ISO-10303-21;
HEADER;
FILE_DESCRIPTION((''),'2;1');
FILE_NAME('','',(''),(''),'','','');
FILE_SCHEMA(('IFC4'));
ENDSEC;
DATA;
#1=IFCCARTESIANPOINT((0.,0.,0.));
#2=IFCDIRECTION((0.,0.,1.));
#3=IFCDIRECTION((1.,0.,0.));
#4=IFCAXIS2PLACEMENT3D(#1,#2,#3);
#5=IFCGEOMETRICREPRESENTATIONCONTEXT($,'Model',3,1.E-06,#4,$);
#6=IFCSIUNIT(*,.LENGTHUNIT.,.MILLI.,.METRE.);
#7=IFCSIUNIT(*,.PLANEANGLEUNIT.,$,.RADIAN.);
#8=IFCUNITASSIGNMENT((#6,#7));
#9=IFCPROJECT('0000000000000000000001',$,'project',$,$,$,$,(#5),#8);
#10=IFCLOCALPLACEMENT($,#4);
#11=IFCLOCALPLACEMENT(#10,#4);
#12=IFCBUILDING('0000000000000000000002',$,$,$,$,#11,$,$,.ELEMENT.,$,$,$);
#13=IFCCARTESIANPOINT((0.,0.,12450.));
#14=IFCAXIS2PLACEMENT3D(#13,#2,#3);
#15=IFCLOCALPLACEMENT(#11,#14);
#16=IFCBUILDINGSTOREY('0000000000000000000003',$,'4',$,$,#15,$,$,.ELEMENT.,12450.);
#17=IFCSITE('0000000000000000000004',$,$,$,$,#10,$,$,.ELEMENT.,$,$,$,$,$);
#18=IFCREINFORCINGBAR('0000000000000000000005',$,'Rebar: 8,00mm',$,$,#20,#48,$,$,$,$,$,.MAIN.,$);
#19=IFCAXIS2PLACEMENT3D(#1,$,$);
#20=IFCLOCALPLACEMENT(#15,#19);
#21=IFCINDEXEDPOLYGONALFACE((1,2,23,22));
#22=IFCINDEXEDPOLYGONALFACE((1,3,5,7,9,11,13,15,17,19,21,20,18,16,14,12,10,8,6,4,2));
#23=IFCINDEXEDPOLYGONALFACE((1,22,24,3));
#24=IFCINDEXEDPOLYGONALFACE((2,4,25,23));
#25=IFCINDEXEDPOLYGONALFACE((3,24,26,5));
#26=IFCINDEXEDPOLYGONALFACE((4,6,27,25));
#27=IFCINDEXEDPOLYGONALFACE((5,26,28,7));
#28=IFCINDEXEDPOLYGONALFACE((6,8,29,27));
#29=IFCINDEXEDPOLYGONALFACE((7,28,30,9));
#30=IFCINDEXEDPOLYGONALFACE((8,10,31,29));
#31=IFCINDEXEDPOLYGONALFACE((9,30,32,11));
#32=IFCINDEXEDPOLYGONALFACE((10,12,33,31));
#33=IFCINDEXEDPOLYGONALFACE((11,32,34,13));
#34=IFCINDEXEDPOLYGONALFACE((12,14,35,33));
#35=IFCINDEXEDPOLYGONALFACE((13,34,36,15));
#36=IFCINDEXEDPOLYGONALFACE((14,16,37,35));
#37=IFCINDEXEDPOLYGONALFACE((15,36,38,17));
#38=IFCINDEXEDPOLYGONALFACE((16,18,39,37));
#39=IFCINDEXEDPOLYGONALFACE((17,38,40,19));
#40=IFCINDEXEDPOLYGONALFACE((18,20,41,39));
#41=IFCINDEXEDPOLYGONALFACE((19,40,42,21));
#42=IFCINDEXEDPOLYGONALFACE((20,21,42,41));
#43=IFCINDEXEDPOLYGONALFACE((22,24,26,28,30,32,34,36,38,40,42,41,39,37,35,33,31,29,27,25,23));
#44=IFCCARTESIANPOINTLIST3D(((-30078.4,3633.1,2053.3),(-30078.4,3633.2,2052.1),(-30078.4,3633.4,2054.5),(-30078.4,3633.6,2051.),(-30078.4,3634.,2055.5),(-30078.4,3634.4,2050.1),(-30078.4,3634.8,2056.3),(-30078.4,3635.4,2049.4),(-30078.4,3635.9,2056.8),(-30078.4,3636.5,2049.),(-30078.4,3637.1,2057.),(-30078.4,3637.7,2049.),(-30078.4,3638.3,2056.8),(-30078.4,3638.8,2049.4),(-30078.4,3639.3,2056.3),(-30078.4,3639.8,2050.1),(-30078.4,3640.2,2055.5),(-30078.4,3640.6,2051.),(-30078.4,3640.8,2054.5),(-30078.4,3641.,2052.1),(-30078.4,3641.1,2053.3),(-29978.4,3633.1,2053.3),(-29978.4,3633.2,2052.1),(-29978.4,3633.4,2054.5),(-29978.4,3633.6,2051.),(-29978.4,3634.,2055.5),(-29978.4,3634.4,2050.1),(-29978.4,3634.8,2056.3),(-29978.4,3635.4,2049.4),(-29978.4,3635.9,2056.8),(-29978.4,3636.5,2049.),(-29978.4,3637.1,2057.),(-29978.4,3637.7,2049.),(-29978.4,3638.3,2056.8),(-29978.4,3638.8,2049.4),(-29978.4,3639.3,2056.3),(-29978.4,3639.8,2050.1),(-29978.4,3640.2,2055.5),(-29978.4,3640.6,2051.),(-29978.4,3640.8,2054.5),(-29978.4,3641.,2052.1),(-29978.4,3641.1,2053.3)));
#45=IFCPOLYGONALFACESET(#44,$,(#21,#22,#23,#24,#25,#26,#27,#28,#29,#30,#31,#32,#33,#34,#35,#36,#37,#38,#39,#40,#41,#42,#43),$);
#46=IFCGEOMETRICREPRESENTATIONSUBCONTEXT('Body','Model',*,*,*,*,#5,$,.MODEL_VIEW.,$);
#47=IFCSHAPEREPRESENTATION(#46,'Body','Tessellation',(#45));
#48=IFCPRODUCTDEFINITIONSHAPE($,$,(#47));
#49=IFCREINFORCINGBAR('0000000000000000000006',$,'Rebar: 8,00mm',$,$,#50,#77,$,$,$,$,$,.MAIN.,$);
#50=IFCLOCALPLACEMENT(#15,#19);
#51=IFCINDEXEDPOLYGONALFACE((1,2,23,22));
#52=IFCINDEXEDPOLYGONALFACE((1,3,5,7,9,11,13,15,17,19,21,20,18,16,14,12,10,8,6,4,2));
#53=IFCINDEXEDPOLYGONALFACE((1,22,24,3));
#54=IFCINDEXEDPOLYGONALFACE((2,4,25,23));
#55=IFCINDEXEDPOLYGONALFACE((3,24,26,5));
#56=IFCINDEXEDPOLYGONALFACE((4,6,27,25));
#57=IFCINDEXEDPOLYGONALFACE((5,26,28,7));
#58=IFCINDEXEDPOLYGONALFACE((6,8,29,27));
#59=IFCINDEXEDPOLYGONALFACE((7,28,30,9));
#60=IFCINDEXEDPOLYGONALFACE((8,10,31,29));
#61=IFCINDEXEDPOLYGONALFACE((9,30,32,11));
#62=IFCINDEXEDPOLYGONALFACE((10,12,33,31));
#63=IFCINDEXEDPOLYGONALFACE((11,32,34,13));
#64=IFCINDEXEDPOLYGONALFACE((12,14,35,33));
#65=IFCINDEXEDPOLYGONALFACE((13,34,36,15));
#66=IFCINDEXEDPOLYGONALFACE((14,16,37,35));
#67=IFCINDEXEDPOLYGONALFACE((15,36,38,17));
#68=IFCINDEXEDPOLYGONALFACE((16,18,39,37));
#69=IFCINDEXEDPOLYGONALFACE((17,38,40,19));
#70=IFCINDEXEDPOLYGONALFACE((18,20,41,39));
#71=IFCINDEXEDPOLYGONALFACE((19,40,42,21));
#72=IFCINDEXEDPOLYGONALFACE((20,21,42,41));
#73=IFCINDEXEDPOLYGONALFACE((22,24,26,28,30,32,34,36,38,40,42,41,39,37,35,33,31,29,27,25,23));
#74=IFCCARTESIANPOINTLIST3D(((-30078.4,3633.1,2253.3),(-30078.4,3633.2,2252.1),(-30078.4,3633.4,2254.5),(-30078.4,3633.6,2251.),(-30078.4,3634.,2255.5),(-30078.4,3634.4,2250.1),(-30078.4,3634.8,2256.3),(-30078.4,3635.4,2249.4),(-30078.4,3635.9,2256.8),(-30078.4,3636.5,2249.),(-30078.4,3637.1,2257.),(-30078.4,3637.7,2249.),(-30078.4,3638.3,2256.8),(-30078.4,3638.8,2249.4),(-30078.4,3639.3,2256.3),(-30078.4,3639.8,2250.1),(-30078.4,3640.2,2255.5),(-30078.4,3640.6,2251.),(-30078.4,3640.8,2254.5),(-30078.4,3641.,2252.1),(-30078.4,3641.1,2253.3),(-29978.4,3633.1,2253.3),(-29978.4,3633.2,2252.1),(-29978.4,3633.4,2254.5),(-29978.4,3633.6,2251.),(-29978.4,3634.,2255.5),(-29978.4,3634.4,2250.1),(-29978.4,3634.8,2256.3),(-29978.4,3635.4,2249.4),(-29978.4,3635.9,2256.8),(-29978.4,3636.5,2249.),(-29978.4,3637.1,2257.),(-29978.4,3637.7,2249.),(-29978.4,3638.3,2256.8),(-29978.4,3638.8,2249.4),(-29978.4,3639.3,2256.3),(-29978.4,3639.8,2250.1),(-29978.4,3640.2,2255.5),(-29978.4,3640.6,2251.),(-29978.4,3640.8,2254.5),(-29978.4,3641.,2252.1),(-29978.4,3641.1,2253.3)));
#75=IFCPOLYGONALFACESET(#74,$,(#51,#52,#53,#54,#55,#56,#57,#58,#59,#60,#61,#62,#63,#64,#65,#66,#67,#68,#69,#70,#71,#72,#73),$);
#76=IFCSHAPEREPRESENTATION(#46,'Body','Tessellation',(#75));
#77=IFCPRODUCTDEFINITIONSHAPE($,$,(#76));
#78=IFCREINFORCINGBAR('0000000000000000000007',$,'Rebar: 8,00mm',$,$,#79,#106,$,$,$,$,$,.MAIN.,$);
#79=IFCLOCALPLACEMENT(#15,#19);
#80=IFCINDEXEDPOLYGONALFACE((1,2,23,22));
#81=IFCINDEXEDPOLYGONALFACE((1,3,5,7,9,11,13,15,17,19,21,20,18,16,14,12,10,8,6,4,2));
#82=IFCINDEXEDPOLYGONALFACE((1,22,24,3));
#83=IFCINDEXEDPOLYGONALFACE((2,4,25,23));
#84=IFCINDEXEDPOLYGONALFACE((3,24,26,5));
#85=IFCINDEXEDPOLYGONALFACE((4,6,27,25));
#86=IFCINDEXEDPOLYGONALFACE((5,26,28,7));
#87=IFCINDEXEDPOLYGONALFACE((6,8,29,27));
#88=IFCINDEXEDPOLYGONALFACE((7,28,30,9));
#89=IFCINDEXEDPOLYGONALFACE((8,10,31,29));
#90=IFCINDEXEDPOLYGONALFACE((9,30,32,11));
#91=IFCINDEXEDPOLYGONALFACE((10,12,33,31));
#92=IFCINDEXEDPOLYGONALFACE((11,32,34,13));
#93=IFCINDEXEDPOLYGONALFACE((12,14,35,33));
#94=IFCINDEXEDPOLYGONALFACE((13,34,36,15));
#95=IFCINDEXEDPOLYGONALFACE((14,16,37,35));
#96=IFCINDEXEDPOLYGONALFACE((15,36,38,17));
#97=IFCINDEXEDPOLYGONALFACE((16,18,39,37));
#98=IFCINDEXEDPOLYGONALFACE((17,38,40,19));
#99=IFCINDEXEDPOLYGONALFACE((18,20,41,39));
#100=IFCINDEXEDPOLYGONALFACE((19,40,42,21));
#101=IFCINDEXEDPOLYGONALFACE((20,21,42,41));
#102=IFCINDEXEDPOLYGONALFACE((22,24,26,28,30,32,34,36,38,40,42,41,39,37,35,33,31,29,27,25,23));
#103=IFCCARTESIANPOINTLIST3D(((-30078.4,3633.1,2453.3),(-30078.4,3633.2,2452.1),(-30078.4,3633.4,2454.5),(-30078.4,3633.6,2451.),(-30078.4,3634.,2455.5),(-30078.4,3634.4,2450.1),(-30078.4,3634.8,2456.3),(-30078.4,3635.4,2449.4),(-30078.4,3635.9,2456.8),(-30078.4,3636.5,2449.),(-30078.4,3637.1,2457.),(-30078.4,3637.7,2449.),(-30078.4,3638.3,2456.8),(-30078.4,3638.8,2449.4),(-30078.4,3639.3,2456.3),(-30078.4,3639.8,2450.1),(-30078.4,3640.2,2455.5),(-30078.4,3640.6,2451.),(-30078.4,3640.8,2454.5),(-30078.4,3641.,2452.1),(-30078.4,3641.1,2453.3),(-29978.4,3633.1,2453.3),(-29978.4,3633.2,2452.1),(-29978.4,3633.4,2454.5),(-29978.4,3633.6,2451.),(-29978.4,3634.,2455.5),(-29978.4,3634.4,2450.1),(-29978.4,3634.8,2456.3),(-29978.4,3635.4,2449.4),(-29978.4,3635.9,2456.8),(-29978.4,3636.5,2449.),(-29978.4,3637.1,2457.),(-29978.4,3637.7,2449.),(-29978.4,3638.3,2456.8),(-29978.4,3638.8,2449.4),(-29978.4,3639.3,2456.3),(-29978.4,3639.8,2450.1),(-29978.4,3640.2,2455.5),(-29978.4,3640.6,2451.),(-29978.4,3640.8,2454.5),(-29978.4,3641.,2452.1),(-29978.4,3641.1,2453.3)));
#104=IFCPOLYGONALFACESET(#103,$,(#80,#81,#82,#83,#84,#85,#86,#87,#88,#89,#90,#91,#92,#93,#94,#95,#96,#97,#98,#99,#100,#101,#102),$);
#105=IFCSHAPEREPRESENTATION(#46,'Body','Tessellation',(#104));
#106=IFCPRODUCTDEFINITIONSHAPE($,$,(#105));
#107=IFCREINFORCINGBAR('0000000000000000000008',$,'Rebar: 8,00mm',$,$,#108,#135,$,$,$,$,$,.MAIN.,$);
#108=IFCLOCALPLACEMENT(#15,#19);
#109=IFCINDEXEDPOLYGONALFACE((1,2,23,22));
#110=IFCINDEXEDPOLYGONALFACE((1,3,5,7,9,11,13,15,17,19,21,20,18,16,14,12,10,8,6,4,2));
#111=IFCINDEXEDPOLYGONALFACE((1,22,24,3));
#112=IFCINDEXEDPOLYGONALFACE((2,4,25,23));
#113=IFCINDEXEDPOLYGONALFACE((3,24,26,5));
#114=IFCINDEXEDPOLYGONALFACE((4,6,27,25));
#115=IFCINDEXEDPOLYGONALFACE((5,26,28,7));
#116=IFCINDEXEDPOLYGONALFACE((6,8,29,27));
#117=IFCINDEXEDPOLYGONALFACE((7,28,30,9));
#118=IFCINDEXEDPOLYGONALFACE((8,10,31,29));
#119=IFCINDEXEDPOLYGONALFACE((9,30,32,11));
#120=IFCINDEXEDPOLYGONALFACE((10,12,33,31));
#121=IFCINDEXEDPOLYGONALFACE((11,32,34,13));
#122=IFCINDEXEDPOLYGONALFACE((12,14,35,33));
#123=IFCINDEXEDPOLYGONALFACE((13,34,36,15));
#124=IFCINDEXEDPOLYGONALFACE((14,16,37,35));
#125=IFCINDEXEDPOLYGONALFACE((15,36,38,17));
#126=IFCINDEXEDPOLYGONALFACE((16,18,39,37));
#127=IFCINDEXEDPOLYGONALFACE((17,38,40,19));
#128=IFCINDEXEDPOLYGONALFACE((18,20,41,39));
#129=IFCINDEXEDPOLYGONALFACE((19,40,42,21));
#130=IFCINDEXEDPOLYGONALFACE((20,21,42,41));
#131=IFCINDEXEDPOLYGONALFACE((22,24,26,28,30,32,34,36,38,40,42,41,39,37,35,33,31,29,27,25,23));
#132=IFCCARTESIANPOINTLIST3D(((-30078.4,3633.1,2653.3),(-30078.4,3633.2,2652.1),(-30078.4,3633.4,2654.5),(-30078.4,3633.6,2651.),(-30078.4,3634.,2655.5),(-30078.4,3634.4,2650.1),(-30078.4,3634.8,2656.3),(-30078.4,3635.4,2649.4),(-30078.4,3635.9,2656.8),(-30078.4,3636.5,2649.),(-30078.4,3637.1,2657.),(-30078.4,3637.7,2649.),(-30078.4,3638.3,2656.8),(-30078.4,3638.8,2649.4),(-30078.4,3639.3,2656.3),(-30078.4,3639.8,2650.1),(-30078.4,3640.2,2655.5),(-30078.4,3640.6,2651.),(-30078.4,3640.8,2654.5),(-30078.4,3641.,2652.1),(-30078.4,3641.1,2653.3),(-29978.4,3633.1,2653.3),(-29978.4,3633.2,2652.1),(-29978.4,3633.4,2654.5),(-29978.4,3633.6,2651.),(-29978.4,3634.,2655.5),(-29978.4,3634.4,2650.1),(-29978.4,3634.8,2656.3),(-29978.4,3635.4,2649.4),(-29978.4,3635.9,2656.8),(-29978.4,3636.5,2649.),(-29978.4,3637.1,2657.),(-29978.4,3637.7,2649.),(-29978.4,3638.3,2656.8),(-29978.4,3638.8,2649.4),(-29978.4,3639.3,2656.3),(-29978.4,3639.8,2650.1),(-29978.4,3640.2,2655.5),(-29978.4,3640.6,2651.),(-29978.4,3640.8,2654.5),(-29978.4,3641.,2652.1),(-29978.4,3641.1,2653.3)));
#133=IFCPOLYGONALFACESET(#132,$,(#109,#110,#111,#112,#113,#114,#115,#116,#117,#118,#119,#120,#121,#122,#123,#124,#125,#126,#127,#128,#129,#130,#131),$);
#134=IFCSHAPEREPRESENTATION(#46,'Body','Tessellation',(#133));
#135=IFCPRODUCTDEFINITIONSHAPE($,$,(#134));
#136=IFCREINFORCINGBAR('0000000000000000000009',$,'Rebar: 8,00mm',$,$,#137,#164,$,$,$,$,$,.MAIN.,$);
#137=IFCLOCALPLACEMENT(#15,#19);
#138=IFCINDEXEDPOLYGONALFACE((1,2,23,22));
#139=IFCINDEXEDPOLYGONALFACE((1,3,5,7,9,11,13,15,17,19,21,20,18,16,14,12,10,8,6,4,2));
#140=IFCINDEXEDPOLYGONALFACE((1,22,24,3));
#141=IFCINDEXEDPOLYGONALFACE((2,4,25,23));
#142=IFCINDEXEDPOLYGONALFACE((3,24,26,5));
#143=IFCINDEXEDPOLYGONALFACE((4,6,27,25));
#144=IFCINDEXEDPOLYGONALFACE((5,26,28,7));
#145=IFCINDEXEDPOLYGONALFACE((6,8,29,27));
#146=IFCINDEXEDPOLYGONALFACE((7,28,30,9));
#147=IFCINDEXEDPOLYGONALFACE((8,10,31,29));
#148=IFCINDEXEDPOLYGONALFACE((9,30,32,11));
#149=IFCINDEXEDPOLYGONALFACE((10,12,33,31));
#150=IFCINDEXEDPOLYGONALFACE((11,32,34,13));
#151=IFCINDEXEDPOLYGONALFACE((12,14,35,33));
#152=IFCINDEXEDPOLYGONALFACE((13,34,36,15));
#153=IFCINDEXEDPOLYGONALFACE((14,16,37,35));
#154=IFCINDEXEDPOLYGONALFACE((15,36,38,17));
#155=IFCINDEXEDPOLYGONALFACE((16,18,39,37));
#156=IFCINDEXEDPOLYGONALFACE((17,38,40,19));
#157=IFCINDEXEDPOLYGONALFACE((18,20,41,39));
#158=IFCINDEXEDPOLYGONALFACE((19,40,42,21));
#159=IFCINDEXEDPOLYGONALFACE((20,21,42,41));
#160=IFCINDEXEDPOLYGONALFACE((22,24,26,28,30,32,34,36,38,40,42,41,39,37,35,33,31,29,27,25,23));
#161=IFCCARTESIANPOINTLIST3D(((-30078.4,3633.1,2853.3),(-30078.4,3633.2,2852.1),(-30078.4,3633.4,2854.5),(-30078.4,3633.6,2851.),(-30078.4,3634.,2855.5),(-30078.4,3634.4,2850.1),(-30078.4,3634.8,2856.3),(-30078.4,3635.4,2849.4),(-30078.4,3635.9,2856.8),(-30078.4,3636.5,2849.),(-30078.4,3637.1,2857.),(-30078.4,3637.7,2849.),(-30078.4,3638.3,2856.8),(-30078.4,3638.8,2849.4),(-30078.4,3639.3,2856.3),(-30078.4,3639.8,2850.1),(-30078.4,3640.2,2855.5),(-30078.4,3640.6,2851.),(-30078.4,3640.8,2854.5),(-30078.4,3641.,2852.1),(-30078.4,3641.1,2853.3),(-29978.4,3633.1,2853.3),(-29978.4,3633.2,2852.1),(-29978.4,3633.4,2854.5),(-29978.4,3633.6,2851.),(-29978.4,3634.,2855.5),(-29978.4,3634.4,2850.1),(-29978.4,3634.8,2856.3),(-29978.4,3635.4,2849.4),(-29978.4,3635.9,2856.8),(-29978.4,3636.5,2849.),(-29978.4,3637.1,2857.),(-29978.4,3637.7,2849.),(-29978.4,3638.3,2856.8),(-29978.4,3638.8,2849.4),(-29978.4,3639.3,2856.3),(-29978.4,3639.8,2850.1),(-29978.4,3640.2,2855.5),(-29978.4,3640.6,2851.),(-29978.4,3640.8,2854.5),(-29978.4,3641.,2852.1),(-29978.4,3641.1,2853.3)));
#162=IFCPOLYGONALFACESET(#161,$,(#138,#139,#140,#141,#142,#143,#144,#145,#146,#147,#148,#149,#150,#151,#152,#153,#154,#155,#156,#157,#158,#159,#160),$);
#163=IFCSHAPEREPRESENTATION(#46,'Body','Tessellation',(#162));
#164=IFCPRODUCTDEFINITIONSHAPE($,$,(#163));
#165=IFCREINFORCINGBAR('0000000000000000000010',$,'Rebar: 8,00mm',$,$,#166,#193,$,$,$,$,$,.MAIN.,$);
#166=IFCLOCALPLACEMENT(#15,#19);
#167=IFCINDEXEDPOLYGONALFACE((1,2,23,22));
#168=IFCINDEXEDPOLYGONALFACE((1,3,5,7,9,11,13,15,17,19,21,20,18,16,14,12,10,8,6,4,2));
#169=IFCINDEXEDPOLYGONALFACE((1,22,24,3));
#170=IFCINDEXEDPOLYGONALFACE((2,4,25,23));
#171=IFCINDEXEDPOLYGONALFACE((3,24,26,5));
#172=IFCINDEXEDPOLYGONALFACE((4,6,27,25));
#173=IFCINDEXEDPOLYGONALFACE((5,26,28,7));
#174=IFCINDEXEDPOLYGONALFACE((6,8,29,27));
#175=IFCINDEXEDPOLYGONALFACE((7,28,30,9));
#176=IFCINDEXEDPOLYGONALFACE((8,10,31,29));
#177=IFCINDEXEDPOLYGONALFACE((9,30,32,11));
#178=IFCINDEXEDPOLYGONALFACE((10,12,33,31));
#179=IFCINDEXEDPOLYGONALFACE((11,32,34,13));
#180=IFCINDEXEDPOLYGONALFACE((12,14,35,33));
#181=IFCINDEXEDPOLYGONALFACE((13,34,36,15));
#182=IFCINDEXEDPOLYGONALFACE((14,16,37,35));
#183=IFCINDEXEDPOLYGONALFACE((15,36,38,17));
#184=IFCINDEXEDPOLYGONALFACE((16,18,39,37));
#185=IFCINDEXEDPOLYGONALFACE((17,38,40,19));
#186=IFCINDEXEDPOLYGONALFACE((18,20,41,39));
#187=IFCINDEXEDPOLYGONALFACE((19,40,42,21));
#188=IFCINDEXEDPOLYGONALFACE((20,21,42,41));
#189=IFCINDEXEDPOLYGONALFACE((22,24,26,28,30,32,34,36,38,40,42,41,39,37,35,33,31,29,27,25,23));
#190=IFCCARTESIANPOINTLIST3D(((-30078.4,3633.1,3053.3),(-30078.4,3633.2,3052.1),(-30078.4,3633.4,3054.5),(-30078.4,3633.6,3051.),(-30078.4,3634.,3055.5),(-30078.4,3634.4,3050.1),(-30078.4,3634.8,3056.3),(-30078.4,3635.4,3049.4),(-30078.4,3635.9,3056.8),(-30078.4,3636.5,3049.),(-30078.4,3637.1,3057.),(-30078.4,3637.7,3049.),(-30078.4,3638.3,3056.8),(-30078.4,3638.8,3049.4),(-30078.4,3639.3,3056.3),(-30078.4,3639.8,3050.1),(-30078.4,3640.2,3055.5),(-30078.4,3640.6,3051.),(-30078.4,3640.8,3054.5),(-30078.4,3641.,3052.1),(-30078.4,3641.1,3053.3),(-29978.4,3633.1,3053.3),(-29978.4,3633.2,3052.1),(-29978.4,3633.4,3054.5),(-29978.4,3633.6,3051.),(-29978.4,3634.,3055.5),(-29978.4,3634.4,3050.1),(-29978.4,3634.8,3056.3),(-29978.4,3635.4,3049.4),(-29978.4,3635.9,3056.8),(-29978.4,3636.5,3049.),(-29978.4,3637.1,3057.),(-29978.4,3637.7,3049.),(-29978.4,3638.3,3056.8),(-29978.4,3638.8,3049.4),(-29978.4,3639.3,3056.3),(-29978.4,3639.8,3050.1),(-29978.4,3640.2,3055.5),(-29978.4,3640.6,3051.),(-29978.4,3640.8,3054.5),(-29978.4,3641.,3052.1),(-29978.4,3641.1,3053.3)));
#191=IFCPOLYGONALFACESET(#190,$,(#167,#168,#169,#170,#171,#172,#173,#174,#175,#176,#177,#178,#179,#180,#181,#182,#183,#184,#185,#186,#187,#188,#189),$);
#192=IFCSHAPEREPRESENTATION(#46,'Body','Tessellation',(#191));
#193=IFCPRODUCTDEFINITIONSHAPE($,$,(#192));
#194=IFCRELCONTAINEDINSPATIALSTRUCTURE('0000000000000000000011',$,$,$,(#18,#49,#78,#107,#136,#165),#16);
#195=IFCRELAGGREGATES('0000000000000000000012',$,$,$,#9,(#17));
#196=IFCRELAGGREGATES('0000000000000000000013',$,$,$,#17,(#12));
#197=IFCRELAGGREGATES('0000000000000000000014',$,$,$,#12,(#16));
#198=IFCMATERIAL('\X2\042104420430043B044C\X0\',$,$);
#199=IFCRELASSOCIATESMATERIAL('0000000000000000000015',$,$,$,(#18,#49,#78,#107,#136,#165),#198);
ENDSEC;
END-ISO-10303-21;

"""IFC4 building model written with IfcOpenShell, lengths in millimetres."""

from ifc_helpers import new_model, entity, si_unit, frame, origin_with_axes, place, context, subcontext, project, spatial, source, transform, mapped, material, element, save


model = new_model("IFC4")

# Units and contexts
model_context = context("Model", 3, precision=1e-06, world=origin_with_axes())
body_context = subcontext(model_context, "Body", "Model", "MODEL_VIEW")
ifc_project = project(units=[si_unit("LENGTHUNIT", "METRE", prefix="MILLI"), si_unit("PLANEANGLEUNIT", "RADIAN")], contexts=[model_context])

# Site, building, storey
site_placement = place(None, origin_with_axes())
site = spatial("IfcSite", under=ifc_project, at=site_placement, CompositionType="ELEMENT")
building_placement = place(site_placement, origin_with_axes())
building = spatial("IfcBuilding", under=site, at=building_placement, CompositionType="ELEMENT")
storey_placement = place(building_placement, frame((0.0, 0.0, 12450.0), z_axis=(0.0, 0.0, 1.0), x_axis=(1.0, 0.0, 0.0)))
storey = spatial("IfcBuildingStorey", under=building, at=storey_placement, Name="4", CompositionType="ELEMENT", Elevation=12450.0)

# Reinforcing bars
ifc_material = material(Name="Сталь")
shared_shape_1 = source(origin_with_axes(), body_context, "Body", "AdvancedSweptSolid", [
    entity("IfcSweptDiskSolid", entity("IfcIndexedPolyCurve", entity("IfcCartesianPointList3D", [[0.0, 0.0, 0.0], [100.0, 0.0, 0.0]]), [entity("IfcLineIndex", [1, 2])]), 4.0),
])
reinforcing_bar_1_placement = place(storey_placement, origin_with_axes())
element("IfcReinforcingBar", 1, at=reinforcing_bar_1_placement, inside=storey, material=ifc_material, Name="Rebar: 8,00mm", PredefinedType="MAIN", context=body_context, shape_type="MappedRepresentation", body=[
    mapped(shared_shape_1, transform((-29978.4, 3637.1, 2053.0), x_axis=(-1.0, 0.0, 0.0), y_axis=(0.0, -1.0, 0.0), z_axis=(0.0, 0.0, 1.0), scale=1.0)),
])
reinforcing_bar_2_placement = place(storey_placement, origin_with_axes())
element("IfcReinforcingBar", 2, at=reinforcing_bar_2_placement, inside=storey, material=ifc_material, Name="Rebar: 8,00mm", PredefinedType="MAIN", context=body_context, shape_type="MappedRepresentation", body=[
    mapped(shared_shape_1, transform((-29978.4, 3637.1, 2253.0), x_axis=(-1.0, 0.0, 0.0), y_axis=(0.0, -1.0, 0.0), z_axis=(0.0, 0.0, 1.0), scale=1.0)),
])
reinforcing_bar_3_placement = place(storey_placement, origin_with_axes())
element("IfcReinforcingBar", 3, at=reinforcing_bar_3_placement, inside=storey, material=ifc_material, Name="Rebar: 8,00mm", PredefinedType="MAIN", context=body_context, shape_type="MappedRepresentation", body=[
    mapped(shared_shape_1, transform((-29978.4, 3637.1, 2453.0), x_axis=(-1.0, 0.0, 0.0), y_axis=(0.0, -1.0, 0.0), z_axis=(0.0, 0.0, 1.0), scale=1.0)),
])
reinforcing_bar_4_placement = place(storey_placement, origin_with_axes())
element("IfcReinforcingBar", 4, at=reinforcing_bar_4_placement, inside=storey, material=ifc_material, Name="Rebar: 8,00mm", PredefinedType="MAIN", context=body_context, shape_type="MappedRepresentation", body=[
    mapped(shared_shape_1, transform((-29978.4, 3637.1, 2653.0), x_axis=(-1.0, 0.0, 0.0), y_axis=(0.0, -1.0, 0.0), z_axis=(0.0, 0.0, 1.0), scale=1.0)),
])
reinforcing_bar_5_placement = place(storey_placement, origin_with_axes())
element("IfcReinforcingBar", 5, at=reinforcing_bar_5_placement, inside=storey, material=ifc_material, Name="Rebar: 8,00mm", PredefinedType="MAIN", context=body_context, shape_type="MappedRepresentation", body=[
    mapped(shared_shape_1, transform((-29978.4, 3637.1, 2853.0), x_axis=(-1.0, 0.0, 0.0), y_axis=(0.0, -1.0, 0.0), z_axis=(0.0, 0.0, 1.0), scale=1.0)),
])
reinforcing_bar_6_placement = place(storey_placement, origin_with_axes())
element("IfcReinforcingBar", 6, at=reinforcing_bar_6_placement, inside=storey, material=ifc_material, Name="Rebar: 8,00mm", PredefinedType="MAIN", context=body_context, shape_type="MappedRepresentation", body=[
    mapped(shared_shape_1, transform((-29978.4, 3637.1, 3053.0), x_axis=(-1.0, 0.0, 0.0), y_axis=(0.0, -1.0, 0.0), z_axis=(0.0, 0.0, 1.0), scale=1.0)),
])

save(model, "model.ifc")
